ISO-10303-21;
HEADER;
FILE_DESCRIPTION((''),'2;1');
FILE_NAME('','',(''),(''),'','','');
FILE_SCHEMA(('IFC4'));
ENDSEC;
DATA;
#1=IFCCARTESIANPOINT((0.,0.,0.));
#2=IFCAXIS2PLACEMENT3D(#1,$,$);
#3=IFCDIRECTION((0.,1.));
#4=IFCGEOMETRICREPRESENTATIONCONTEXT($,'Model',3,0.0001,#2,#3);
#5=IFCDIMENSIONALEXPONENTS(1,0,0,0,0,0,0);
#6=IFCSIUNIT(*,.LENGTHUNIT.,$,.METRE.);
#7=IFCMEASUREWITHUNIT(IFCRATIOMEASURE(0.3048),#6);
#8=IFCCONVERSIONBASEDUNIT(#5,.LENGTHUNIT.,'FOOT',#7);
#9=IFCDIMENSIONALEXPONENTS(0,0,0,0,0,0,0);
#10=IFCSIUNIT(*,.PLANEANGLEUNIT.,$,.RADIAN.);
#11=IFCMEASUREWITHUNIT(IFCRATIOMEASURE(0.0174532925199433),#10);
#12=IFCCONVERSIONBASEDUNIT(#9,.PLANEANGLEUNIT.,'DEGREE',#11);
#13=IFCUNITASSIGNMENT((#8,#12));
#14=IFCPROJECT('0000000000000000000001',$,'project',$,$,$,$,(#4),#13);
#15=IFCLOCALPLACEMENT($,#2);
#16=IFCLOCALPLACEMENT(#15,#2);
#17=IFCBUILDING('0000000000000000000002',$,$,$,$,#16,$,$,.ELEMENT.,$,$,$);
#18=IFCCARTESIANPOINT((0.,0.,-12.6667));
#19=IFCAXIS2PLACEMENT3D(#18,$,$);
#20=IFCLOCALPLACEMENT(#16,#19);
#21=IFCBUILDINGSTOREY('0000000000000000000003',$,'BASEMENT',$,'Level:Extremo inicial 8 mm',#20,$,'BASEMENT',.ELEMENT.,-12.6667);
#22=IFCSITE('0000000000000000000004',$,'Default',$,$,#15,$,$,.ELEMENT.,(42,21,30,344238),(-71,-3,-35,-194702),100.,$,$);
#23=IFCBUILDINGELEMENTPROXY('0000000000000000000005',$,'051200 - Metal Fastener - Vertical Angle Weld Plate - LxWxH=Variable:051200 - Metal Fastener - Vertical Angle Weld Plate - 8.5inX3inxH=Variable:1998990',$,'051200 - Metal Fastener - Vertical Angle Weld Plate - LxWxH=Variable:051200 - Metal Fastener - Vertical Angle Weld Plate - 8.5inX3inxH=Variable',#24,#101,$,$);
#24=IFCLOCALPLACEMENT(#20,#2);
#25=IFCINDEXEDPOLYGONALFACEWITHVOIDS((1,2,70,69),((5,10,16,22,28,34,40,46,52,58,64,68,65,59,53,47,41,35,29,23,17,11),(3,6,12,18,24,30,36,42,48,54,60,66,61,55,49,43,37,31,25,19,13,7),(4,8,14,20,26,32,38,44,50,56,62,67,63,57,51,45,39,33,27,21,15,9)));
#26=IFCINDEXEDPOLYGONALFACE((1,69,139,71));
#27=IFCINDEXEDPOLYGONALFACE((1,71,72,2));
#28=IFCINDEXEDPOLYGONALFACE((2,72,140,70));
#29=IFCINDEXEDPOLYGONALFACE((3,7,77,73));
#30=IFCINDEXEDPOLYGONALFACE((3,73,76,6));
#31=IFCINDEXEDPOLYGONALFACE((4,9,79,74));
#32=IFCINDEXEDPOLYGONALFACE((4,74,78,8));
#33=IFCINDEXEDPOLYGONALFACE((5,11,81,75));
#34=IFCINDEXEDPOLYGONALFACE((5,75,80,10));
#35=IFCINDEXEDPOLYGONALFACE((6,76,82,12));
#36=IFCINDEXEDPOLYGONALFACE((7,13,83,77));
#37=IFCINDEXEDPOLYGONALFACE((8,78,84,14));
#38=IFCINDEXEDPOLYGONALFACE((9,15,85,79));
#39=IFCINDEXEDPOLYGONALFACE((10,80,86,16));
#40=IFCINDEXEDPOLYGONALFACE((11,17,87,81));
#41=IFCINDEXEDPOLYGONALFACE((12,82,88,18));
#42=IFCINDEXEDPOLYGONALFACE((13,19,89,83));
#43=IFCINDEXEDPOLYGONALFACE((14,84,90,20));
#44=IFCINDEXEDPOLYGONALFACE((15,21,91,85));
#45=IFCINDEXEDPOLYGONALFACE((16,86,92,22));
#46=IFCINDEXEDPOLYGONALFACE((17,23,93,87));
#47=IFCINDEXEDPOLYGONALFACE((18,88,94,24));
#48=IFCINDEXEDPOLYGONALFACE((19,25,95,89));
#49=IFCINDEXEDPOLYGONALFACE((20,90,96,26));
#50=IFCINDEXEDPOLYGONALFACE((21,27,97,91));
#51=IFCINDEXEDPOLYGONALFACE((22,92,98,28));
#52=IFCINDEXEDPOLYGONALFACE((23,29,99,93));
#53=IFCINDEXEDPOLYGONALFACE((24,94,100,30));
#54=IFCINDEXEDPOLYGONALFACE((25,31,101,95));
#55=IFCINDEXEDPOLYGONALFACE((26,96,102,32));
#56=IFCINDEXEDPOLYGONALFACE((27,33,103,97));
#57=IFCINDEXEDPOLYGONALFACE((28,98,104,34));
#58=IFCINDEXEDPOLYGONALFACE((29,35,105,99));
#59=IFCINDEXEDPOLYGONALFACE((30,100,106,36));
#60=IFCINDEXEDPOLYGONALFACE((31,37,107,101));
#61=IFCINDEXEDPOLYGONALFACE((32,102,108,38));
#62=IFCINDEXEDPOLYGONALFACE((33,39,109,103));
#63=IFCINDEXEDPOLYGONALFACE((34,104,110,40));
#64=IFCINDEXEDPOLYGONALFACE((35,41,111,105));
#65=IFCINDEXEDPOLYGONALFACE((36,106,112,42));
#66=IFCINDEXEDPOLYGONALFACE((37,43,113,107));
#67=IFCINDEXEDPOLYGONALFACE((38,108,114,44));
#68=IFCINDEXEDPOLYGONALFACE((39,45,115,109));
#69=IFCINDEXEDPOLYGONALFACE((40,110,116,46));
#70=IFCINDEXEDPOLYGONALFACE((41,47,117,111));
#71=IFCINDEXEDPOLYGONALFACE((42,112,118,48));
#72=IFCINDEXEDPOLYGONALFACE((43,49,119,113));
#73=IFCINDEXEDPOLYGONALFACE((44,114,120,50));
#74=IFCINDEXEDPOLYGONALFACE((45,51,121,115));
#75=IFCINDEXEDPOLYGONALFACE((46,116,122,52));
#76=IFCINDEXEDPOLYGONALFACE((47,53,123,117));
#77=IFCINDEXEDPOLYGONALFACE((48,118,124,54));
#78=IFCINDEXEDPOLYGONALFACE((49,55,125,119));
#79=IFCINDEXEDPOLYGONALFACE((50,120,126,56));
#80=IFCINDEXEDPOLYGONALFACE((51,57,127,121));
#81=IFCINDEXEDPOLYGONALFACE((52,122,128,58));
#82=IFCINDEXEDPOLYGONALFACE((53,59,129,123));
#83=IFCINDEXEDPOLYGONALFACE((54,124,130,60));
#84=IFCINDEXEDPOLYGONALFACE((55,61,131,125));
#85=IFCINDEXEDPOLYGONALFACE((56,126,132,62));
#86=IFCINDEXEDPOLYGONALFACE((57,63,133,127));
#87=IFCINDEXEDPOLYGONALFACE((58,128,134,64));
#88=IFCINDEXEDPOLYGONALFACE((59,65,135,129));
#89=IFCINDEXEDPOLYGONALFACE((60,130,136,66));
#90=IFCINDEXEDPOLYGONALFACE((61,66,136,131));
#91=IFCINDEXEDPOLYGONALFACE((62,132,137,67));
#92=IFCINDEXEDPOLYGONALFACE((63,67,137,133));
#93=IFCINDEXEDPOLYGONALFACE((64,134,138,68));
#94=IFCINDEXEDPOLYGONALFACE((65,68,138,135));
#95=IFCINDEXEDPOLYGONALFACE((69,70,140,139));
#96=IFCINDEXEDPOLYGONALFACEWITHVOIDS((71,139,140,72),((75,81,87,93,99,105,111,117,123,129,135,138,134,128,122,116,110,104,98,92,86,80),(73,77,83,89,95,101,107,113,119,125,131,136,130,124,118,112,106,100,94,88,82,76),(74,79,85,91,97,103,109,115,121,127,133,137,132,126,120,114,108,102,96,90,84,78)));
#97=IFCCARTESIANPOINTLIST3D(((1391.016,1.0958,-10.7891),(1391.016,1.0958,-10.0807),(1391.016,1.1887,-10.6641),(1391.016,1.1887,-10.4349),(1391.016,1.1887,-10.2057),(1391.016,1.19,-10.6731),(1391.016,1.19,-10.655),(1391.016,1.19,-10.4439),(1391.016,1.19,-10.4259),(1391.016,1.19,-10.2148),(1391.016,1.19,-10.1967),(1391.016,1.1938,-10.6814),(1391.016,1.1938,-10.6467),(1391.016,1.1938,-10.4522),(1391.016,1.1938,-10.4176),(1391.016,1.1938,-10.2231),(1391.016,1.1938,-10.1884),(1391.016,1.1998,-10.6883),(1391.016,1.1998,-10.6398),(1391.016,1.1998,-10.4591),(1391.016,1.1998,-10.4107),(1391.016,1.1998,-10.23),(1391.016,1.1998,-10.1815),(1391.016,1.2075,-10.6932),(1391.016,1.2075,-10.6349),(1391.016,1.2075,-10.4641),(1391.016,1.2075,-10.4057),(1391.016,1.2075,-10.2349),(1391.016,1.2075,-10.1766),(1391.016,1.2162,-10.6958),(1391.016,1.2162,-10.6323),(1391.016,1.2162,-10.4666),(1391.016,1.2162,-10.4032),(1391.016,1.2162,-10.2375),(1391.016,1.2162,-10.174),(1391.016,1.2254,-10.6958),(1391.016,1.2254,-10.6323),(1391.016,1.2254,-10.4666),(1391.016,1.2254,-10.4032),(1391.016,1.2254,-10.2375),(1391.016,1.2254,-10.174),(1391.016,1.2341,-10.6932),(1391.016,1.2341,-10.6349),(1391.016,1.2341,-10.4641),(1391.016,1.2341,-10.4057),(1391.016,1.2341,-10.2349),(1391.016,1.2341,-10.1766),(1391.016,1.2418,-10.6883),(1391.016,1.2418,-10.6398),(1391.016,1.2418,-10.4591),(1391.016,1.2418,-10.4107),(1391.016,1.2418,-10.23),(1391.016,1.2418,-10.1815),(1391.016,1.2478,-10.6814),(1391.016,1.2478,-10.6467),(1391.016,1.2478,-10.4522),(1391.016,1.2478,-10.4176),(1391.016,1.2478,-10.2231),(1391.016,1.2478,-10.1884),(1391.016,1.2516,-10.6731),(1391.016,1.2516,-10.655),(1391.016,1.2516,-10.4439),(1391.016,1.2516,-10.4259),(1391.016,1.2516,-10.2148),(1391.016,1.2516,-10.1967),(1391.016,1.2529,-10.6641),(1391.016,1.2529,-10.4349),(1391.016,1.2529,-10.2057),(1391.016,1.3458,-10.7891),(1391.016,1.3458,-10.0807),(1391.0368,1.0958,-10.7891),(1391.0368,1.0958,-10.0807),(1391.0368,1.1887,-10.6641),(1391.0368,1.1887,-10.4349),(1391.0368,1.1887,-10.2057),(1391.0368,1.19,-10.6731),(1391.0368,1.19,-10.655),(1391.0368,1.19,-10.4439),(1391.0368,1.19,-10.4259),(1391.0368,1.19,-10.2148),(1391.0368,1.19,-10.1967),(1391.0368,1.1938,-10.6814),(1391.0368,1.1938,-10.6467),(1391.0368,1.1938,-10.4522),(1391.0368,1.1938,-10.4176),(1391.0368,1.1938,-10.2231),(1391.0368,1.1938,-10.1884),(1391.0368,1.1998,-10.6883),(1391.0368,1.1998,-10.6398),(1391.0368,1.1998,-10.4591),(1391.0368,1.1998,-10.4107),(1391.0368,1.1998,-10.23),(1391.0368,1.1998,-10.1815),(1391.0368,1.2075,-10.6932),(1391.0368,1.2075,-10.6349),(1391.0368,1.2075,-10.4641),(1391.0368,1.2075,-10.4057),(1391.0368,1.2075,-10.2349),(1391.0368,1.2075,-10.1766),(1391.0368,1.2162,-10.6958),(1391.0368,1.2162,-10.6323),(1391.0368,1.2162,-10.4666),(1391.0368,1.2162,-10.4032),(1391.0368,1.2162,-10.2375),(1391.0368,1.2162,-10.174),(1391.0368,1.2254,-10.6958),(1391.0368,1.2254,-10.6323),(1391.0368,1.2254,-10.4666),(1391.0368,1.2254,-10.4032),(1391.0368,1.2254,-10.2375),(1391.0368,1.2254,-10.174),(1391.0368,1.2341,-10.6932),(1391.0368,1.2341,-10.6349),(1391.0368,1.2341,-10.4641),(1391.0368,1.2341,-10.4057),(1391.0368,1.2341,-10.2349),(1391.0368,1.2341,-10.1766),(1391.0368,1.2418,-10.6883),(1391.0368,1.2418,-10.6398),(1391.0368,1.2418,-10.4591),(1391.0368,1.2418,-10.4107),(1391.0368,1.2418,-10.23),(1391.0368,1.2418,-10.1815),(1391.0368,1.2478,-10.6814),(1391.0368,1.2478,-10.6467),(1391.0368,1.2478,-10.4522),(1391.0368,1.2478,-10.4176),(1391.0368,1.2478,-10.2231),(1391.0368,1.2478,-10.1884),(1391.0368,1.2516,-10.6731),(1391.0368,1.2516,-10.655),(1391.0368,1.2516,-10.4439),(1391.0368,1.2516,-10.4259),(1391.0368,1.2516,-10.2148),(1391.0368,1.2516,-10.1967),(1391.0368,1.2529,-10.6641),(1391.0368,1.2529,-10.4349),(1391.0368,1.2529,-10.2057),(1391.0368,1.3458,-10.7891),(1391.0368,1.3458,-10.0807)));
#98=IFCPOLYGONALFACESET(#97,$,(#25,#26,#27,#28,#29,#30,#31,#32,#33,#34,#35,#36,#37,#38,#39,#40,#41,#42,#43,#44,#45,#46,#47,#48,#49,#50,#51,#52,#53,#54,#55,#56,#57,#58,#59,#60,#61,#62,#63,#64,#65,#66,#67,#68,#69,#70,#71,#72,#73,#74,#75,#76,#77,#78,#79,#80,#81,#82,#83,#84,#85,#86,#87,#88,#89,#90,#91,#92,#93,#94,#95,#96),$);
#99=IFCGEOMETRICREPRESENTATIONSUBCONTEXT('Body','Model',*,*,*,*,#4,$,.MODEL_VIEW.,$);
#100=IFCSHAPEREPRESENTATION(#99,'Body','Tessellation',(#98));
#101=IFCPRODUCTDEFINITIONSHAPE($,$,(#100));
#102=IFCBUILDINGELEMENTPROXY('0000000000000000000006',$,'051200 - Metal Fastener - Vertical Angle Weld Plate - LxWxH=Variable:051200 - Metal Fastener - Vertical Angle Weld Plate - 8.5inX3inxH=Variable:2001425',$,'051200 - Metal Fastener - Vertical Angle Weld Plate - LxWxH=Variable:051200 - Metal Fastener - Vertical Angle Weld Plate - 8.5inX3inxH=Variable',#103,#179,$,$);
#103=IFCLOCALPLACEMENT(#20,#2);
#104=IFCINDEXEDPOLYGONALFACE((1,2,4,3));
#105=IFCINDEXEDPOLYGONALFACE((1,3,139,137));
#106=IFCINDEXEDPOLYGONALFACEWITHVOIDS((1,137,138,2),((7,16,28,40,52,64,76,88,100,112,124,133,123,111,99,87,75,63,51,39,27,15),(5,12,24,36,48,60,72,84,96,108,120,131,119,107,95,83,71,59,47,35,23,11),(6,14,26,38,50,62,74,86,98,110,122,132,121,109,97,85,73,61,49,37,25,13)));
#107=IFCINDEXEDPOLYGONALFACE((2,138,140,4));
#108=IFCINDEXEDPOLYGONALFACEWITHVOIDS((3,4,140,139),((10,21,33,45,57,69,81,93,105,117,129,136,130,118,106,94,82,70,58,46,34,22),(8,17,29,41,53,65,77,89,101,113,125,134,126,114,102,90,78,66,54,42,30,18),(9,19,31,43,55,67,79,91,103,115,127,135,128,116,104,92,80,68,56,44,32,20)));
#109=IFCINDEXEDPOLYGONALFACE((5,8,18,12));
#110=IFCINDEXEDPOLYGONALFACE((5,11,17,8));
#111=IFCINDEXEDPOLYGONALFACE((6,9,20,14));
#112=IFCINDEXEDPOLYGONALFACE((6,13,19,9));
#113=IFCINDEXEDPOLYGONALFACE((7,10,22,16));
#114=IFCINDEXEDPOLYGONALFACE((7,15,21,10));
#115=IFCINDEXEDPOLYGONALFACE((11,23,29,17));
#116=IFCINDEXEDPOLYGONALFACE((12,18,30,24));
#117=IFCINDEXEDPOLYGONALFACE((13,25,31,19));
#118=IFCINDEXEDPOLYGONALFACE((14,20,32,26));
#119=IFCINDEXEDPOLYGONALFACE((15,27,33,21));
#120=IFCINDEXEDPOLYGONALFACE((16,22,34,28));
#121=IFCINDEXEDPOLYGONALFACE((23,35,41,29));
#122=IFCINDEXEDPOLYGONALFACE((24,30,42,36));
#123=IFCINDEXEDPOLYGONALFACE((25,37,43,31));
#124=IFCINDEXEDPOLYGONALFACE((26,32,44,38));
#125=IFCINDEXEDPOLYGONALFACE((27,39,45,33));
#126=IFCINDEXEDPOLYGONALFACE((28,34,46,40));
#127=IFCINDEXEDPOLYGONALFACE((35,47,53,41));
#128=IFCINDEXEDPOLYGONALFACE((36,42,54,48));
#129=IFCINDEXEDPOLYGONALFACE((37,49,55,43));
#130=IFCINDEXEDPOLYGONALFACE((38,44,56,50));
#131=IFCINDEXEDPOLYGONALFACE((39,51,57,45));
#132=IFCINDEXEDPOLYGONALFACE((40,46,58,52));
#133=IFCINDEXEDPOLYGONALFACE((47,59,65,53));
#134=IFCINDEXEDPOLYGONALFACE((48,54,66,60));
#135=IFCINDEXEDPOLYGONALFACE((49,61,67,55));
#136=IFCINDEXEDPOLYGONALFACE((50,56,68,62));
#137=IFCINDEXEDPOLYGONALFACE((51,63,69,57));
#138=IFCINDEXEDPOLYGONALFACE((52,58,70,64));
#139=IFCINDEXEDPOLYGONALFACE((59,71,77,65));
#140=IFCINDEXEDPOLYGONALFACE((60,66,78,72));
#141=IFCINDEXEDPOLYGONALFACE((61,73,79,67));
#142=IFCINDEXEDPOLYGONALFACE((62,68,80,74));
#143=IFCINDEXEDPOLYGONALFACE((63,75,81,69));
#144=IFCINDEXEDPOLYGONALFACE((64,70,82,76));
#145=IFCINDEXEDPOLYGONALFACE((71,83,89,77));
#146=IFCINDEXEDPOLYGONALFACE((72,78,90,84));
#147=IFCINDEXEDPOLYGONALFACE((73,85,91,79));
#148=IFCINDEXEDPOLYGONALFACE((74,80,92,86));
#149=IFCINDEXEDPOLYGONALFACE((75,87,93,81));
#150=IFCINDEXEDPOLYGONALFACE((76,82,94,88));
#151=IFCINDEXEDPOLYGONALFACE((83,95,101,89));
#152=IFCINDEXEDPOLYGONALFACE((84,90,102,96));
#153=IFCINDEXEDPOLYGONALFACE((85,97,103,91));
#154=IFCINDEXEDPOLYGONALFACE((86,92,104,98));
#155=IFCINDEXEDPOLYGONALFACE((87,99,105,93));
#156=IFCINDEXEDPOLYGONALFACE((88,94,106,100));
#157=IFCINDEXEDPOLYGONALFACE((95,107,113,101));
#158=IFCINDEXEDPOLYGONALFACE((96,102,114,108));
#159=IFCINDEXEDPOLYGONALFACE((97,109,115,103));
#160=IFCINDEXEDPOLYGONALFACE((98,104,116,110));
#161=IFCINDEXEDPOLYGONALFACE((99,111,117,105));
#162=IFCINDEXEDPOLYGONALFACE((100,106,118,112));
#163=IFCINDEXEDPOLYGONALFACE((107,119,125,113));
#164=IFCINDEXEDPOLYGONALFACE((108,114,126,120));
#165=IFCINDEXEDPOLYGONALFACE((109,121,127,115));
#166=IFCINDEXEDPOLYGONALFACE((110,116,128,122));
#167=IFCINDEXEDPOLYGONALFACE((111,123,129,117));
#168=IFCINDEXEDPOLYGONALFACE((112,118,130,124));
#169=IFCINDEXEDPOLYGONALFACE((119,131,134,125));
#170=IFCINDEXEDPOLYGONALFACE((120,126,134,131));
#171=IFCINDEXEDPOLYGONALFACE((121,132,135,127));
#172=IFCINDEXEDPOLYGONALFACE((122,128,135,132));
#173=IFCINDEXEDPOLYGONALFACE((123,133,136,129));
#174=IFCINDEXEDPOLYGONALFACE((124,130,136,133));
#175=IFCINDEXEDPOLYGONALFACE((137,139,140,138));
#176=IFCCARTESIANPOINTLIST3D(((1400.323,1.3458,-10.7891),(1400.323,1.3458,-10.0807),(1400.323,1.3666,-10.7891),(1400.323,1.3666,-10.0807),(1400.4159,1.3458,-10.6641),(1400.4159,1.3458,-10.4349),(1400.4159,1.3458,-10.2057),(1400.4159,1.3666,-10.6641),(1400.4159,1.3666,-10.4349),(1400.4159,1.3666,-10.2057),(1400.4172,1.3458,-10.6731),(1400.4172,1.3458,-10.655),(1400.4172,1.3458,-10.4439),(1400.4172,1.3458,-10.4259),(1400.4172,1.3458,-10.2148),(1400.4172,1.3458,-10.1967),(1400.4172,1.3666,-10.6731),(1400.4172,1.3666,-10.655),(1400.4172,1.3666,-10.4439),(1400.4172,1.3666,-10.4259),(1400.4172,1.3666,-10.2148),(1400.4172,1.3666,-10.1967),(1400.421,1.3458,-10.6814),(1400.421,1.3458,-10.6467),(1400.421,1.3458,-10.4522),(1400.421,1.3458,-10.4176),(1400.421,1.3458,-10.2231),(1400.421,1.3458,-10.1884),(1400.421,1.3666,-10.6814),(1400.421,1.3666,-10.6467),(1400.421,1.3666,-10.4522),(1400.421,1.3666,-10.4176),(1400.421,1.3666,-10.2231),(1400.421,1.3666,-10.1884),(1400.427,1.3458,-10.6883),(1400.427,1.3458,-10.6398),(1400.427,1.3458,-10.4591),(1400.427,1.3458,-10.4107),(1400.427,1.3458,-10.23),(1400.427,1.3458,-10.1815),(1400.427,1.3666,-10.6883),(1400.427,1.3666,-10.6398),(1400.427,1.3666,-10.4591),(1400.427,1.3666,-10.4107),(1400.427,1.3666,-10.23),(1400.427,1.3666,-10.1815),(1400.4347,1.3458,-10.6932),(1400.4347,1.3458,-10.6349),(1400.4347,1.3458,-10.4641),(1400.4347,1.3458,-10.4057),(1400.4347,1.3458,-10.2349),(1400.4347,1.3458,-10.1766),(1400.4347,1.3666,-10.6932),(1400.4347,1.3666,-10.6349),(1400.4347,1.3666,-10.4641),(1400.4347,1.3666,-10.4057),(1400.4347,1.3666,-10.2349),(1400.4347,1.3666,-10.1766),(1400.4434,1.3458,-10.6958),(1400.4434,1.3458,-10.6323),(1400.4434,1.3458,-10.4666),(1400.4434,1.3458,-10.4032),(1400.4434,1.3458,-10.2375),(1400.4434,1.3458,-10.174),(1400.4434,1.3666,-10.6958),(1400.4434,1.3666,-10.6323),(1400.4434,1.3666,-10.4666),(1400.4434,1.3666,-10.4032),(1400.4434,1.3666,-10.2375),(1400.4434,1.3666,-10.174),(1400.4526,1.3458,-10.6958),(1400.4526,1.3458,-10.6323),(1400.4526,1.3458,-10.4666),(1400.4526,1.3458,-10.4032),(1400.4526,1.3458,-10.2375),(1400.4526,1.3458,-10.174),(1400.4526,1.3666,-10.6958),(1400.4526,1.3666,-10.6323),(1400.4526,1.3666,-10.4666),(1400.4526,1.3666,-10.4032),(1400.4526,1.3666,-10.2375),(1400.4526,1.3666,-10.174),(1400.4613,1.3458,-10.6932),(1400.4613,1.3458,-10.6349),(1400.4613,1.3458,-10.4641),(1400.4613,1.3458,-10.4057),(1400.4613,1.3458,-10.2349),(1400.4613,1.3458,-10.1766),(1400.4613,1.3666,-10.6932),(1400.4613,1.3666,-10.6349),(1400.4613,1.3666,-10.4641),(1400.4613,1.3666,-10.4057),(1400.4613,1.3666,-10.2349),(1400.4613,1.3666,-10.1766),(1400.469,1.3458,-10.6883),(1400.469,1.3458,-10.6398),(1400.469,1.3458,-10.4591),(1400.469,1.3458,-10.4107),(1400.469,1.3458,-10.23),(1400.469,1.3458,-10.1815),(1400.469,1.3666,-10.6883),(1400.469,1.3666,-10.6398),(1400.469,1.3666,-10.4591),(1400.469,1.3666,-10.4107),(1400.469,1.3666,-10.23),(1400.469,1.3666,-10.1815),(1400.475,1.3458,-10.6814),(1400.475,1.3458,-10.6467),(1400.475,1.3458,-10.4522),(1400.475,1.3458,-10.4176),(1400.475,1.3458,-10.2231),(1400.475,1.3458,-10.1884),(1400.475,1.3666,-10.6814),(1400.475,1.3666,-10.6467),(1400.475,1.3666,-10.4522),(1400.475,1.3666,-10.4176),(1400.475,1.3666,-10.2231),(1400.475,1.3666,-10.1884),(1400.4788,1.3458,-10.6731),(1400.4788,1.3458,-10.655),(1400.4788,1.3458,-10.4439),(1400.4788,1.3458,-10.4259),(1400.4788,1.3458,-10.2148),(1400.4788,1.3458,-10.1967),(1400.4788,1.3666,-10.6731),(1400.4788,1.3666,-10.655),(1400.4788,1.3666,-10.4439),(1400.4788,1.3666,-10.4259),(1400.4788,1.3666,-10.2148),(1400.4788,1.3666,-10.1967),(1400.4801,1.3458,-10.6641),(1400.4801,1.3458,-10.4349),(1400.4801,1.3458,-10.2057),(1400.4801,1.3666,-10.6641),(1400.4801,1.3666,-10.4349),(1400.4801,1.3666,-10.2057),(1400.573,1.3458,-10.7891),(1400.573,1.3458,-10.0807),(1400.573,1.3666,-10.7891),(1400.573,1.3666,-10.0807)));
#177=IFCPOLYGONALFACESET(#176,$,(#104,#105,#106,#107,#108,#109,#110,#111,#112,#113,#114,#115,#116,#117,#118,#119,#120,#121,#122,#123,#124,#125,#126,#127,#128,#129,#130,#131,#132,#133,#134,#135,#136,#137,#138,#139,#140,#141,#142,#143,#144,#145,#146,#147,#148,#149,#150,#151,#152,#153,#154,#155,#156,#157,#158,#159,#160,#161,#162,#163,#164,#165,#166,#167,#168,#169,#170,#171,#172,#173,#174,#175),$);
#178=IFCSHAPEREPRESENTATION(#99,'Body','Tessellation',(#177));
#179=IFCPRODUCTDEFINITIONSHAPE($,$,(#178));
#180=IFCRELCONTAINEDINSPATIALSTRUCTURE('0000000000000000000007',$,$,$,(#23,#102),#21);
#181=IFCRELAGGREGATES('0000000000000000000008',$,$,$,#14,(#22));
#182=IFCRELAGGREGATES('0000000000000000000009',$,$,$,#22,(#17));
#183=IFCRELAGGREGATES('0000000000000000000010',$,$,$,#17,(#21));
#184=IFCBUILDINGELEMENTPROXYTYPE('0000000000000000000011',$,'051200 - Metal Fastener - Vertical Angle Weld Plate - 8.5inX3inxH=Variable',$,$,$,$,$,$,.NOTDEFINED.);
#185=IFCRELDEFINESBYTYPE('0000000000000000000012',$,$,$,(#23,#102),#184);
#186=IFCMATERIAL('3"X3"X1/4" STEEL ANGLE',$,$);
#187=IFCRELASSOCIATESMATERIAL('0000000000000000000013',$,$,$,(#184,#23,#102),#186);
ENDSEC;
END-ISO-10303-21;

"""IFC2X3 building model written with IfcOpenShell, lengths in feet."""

from ifc_helpers import new_model, entity, si_unit, converted_unit, direction, frame, frame_2d, origin, place, context, subcontext, project, spatial, polyline, circle_curve, parameter, trimmed, segment, composite_curve, outline, extrude, source, transform, mapped, material, type_object, type_shapes, element, save


model = new_model("IFC2X3")

# Units and contexts
model_context = context("Model", 3, precision=0.0001, world=origin(), true_north=direction((0.0, 1.0)))
body_context = subcontext(model_context, "Body", "Model", "MODEL_VIEW")
ifc_project = project(units=[converted_unit("LENGTHUNIT", "FOOT", entity("IfcRatioMeasure", 0.3048), si_unit("LENGTHUNIT", "METRE"), dimensions=[1, 0, 0, 0, 0, 0, 0]), converted_unit("PLANEANGLEUNIT", "DEGREE", entity("IfcRatioMeasure", 0.0174532925199433), si_unit("PLANEANGLEUNIT", "RADIAN"), dimensions=[0, 0, 0, 0, 0, 0, 0])], contexts=[model_context])

# Site, building, storey
site_placement = place(None, origin())
site = spatial("IfcSite", under=ifc_project, at=site_placement, Name="Default", CompositionType="ELEMENT", RefLatitude=(42, 21, 30, 344238), RefLongitude=(-71, -3, -35, -194702), RefElevation=100.0)
building_placement = place(site_placement, origin())
building = spatial("IfcBuilding", under=site, at=building_placement, CompositionType="ELEMENT")
storey_placement = place(building_placement, frame((0.0, 0.0, -12.6667)))
storey = spatial("IfcBuildingStorey", under=building, at=storey_placement, Name="BASEMENT", ObjectType="Level:Extremo inicial 8 mm", LongName="BASEMENT", CompositionType="ELEMENT", Elevation=-12.6667)

# Building element proxies
ifc_material_1 = material(Name="3\"X3\"X1/4\" STEEL ANGLE")
building_element_proxy_type_1 = type_object("IfcBuildingElementProxyType", Name="051200 - Metal Fastener - Vertical Angle Weld Plate - 8.5inX3inxH=Variable", PredefinedType="NOTDEFINED", material=ifc_material_1)
shared_shape_1 = source(origin(), body_context, "Body", "SweptSolid", [
    extrude(outline(polyline([(-0.125, -0.3542), (0.125, -0.3542), (0.125, 0.3542), (-0.125, 0.3542), (-0.125, -0.3542)]), holes=[composite_curve([segment(trimmed(circle_curve(frame_2d((0.0, -0.2292), x_axis=(-1.0, 0.0)), 0.0321), [parameter(180.0)], [parameter(0.0)], True, "PARAMETER"), False, "CONTINUOUS"), segment(trimmed(circle_curve(frame_2d((0.0, -0.2292), x_axis=(-1.0, 0.0)), 0.0321), [parameter(0.0)], [parameter(180.0)], True, "PARAMETER"), False, "CONTINUOUS")], self_intersect=False), composite_curve([segment(trimmed(circle_curve(frame_2d((0.0, 0.0), x_axis=(-1.0, 0.0)), 0.0321), [parameter(180.0)], [parameter(0.0)], True, "PARAMETER"), False, "CONTINUOUS"), segment(trimmed(circle_curve(frame_2d((0.0, 0.0), x_axis=(-1.0, 0.0)), 0.0321), [parameter(0.0)], [parameter(180.0)], True, "PARAMETER"), False, "CONTINUOUS")], self_intersect=False), composite_curve([segment(trimmed(circle_curve(frame_2d((0.0, 0.2292), x_axis=(-1.0, 0.0)), 0.0321), [parameter(180.0)], [parameter(0.0)], True, "PARAMETER"), False, "CONTINUOUS"), segment(trimmed(circle_curve(frame_2d((0.0, 0.2292), x_axis=(-1.0, 0.0)), 0.0321), [parameter(0.0)], [parameter(180.0)], True, "PARAMETER"), False, "CONTINUOUS")], self_intersect=False)]), frame((0.0, 0.0, 0.0), z_axis=(0.0, 0.0, 1.0), x_axis=(-1.0, 0.0, 0.0)), (0.0, 0.0, 1.0), 0.0208),
])
type_shapes(building_element_proxy_type_1, [shared_shape_1])
for number, where, z_axis, x_axis, name in (
    (1, (1391.016, 1.2208, -10.4349), (1.0, 0.0, 0.0), (0.0, 1.0, 0.0), "051200 - Metal Fastener - Vertical Angle Weld Plate - LxWxH=Variable:051200 - Metal Fastener - Vertical Angle Weld Plate - 8.5inX3inxH=Variable:1998990"),
    (2, (1400.448, 1.3666, -10.4349), (0.0, -1.0, 0.0), (1.0, 0.0, 0.0), "051200 - Metal Fastener - Vertical Angle Weld Plate - LxWxH=Variable:051200 - Metal Fastener - Vertical Angle Weld Plate - 8.5inX3inxH=Variable:2001425"),
):
    element("IfcBuildingElementProxy", number, at=place(storey_placement, frame(where, z_axis=z_axis, x_axis=x_axis)), inside=storey, type_object=building_element_proxy_type_1, material=ifc_material_1, Name=name, ObjectType="051200 - Metal Fastener - Vertical Angle Weld Plate - LxWxH=Variable:051200 - Metal Fastener - Vertical Angle Weld Plate - 8.5inX3inxH=Variable", context=body_context, shape_type="MappedRepresentation", body=[
        mapped(shared_shape_1, transform((0.0, 0.0, 0.0), scale=1.0)),
    ])

save(model, "model.ifc")
